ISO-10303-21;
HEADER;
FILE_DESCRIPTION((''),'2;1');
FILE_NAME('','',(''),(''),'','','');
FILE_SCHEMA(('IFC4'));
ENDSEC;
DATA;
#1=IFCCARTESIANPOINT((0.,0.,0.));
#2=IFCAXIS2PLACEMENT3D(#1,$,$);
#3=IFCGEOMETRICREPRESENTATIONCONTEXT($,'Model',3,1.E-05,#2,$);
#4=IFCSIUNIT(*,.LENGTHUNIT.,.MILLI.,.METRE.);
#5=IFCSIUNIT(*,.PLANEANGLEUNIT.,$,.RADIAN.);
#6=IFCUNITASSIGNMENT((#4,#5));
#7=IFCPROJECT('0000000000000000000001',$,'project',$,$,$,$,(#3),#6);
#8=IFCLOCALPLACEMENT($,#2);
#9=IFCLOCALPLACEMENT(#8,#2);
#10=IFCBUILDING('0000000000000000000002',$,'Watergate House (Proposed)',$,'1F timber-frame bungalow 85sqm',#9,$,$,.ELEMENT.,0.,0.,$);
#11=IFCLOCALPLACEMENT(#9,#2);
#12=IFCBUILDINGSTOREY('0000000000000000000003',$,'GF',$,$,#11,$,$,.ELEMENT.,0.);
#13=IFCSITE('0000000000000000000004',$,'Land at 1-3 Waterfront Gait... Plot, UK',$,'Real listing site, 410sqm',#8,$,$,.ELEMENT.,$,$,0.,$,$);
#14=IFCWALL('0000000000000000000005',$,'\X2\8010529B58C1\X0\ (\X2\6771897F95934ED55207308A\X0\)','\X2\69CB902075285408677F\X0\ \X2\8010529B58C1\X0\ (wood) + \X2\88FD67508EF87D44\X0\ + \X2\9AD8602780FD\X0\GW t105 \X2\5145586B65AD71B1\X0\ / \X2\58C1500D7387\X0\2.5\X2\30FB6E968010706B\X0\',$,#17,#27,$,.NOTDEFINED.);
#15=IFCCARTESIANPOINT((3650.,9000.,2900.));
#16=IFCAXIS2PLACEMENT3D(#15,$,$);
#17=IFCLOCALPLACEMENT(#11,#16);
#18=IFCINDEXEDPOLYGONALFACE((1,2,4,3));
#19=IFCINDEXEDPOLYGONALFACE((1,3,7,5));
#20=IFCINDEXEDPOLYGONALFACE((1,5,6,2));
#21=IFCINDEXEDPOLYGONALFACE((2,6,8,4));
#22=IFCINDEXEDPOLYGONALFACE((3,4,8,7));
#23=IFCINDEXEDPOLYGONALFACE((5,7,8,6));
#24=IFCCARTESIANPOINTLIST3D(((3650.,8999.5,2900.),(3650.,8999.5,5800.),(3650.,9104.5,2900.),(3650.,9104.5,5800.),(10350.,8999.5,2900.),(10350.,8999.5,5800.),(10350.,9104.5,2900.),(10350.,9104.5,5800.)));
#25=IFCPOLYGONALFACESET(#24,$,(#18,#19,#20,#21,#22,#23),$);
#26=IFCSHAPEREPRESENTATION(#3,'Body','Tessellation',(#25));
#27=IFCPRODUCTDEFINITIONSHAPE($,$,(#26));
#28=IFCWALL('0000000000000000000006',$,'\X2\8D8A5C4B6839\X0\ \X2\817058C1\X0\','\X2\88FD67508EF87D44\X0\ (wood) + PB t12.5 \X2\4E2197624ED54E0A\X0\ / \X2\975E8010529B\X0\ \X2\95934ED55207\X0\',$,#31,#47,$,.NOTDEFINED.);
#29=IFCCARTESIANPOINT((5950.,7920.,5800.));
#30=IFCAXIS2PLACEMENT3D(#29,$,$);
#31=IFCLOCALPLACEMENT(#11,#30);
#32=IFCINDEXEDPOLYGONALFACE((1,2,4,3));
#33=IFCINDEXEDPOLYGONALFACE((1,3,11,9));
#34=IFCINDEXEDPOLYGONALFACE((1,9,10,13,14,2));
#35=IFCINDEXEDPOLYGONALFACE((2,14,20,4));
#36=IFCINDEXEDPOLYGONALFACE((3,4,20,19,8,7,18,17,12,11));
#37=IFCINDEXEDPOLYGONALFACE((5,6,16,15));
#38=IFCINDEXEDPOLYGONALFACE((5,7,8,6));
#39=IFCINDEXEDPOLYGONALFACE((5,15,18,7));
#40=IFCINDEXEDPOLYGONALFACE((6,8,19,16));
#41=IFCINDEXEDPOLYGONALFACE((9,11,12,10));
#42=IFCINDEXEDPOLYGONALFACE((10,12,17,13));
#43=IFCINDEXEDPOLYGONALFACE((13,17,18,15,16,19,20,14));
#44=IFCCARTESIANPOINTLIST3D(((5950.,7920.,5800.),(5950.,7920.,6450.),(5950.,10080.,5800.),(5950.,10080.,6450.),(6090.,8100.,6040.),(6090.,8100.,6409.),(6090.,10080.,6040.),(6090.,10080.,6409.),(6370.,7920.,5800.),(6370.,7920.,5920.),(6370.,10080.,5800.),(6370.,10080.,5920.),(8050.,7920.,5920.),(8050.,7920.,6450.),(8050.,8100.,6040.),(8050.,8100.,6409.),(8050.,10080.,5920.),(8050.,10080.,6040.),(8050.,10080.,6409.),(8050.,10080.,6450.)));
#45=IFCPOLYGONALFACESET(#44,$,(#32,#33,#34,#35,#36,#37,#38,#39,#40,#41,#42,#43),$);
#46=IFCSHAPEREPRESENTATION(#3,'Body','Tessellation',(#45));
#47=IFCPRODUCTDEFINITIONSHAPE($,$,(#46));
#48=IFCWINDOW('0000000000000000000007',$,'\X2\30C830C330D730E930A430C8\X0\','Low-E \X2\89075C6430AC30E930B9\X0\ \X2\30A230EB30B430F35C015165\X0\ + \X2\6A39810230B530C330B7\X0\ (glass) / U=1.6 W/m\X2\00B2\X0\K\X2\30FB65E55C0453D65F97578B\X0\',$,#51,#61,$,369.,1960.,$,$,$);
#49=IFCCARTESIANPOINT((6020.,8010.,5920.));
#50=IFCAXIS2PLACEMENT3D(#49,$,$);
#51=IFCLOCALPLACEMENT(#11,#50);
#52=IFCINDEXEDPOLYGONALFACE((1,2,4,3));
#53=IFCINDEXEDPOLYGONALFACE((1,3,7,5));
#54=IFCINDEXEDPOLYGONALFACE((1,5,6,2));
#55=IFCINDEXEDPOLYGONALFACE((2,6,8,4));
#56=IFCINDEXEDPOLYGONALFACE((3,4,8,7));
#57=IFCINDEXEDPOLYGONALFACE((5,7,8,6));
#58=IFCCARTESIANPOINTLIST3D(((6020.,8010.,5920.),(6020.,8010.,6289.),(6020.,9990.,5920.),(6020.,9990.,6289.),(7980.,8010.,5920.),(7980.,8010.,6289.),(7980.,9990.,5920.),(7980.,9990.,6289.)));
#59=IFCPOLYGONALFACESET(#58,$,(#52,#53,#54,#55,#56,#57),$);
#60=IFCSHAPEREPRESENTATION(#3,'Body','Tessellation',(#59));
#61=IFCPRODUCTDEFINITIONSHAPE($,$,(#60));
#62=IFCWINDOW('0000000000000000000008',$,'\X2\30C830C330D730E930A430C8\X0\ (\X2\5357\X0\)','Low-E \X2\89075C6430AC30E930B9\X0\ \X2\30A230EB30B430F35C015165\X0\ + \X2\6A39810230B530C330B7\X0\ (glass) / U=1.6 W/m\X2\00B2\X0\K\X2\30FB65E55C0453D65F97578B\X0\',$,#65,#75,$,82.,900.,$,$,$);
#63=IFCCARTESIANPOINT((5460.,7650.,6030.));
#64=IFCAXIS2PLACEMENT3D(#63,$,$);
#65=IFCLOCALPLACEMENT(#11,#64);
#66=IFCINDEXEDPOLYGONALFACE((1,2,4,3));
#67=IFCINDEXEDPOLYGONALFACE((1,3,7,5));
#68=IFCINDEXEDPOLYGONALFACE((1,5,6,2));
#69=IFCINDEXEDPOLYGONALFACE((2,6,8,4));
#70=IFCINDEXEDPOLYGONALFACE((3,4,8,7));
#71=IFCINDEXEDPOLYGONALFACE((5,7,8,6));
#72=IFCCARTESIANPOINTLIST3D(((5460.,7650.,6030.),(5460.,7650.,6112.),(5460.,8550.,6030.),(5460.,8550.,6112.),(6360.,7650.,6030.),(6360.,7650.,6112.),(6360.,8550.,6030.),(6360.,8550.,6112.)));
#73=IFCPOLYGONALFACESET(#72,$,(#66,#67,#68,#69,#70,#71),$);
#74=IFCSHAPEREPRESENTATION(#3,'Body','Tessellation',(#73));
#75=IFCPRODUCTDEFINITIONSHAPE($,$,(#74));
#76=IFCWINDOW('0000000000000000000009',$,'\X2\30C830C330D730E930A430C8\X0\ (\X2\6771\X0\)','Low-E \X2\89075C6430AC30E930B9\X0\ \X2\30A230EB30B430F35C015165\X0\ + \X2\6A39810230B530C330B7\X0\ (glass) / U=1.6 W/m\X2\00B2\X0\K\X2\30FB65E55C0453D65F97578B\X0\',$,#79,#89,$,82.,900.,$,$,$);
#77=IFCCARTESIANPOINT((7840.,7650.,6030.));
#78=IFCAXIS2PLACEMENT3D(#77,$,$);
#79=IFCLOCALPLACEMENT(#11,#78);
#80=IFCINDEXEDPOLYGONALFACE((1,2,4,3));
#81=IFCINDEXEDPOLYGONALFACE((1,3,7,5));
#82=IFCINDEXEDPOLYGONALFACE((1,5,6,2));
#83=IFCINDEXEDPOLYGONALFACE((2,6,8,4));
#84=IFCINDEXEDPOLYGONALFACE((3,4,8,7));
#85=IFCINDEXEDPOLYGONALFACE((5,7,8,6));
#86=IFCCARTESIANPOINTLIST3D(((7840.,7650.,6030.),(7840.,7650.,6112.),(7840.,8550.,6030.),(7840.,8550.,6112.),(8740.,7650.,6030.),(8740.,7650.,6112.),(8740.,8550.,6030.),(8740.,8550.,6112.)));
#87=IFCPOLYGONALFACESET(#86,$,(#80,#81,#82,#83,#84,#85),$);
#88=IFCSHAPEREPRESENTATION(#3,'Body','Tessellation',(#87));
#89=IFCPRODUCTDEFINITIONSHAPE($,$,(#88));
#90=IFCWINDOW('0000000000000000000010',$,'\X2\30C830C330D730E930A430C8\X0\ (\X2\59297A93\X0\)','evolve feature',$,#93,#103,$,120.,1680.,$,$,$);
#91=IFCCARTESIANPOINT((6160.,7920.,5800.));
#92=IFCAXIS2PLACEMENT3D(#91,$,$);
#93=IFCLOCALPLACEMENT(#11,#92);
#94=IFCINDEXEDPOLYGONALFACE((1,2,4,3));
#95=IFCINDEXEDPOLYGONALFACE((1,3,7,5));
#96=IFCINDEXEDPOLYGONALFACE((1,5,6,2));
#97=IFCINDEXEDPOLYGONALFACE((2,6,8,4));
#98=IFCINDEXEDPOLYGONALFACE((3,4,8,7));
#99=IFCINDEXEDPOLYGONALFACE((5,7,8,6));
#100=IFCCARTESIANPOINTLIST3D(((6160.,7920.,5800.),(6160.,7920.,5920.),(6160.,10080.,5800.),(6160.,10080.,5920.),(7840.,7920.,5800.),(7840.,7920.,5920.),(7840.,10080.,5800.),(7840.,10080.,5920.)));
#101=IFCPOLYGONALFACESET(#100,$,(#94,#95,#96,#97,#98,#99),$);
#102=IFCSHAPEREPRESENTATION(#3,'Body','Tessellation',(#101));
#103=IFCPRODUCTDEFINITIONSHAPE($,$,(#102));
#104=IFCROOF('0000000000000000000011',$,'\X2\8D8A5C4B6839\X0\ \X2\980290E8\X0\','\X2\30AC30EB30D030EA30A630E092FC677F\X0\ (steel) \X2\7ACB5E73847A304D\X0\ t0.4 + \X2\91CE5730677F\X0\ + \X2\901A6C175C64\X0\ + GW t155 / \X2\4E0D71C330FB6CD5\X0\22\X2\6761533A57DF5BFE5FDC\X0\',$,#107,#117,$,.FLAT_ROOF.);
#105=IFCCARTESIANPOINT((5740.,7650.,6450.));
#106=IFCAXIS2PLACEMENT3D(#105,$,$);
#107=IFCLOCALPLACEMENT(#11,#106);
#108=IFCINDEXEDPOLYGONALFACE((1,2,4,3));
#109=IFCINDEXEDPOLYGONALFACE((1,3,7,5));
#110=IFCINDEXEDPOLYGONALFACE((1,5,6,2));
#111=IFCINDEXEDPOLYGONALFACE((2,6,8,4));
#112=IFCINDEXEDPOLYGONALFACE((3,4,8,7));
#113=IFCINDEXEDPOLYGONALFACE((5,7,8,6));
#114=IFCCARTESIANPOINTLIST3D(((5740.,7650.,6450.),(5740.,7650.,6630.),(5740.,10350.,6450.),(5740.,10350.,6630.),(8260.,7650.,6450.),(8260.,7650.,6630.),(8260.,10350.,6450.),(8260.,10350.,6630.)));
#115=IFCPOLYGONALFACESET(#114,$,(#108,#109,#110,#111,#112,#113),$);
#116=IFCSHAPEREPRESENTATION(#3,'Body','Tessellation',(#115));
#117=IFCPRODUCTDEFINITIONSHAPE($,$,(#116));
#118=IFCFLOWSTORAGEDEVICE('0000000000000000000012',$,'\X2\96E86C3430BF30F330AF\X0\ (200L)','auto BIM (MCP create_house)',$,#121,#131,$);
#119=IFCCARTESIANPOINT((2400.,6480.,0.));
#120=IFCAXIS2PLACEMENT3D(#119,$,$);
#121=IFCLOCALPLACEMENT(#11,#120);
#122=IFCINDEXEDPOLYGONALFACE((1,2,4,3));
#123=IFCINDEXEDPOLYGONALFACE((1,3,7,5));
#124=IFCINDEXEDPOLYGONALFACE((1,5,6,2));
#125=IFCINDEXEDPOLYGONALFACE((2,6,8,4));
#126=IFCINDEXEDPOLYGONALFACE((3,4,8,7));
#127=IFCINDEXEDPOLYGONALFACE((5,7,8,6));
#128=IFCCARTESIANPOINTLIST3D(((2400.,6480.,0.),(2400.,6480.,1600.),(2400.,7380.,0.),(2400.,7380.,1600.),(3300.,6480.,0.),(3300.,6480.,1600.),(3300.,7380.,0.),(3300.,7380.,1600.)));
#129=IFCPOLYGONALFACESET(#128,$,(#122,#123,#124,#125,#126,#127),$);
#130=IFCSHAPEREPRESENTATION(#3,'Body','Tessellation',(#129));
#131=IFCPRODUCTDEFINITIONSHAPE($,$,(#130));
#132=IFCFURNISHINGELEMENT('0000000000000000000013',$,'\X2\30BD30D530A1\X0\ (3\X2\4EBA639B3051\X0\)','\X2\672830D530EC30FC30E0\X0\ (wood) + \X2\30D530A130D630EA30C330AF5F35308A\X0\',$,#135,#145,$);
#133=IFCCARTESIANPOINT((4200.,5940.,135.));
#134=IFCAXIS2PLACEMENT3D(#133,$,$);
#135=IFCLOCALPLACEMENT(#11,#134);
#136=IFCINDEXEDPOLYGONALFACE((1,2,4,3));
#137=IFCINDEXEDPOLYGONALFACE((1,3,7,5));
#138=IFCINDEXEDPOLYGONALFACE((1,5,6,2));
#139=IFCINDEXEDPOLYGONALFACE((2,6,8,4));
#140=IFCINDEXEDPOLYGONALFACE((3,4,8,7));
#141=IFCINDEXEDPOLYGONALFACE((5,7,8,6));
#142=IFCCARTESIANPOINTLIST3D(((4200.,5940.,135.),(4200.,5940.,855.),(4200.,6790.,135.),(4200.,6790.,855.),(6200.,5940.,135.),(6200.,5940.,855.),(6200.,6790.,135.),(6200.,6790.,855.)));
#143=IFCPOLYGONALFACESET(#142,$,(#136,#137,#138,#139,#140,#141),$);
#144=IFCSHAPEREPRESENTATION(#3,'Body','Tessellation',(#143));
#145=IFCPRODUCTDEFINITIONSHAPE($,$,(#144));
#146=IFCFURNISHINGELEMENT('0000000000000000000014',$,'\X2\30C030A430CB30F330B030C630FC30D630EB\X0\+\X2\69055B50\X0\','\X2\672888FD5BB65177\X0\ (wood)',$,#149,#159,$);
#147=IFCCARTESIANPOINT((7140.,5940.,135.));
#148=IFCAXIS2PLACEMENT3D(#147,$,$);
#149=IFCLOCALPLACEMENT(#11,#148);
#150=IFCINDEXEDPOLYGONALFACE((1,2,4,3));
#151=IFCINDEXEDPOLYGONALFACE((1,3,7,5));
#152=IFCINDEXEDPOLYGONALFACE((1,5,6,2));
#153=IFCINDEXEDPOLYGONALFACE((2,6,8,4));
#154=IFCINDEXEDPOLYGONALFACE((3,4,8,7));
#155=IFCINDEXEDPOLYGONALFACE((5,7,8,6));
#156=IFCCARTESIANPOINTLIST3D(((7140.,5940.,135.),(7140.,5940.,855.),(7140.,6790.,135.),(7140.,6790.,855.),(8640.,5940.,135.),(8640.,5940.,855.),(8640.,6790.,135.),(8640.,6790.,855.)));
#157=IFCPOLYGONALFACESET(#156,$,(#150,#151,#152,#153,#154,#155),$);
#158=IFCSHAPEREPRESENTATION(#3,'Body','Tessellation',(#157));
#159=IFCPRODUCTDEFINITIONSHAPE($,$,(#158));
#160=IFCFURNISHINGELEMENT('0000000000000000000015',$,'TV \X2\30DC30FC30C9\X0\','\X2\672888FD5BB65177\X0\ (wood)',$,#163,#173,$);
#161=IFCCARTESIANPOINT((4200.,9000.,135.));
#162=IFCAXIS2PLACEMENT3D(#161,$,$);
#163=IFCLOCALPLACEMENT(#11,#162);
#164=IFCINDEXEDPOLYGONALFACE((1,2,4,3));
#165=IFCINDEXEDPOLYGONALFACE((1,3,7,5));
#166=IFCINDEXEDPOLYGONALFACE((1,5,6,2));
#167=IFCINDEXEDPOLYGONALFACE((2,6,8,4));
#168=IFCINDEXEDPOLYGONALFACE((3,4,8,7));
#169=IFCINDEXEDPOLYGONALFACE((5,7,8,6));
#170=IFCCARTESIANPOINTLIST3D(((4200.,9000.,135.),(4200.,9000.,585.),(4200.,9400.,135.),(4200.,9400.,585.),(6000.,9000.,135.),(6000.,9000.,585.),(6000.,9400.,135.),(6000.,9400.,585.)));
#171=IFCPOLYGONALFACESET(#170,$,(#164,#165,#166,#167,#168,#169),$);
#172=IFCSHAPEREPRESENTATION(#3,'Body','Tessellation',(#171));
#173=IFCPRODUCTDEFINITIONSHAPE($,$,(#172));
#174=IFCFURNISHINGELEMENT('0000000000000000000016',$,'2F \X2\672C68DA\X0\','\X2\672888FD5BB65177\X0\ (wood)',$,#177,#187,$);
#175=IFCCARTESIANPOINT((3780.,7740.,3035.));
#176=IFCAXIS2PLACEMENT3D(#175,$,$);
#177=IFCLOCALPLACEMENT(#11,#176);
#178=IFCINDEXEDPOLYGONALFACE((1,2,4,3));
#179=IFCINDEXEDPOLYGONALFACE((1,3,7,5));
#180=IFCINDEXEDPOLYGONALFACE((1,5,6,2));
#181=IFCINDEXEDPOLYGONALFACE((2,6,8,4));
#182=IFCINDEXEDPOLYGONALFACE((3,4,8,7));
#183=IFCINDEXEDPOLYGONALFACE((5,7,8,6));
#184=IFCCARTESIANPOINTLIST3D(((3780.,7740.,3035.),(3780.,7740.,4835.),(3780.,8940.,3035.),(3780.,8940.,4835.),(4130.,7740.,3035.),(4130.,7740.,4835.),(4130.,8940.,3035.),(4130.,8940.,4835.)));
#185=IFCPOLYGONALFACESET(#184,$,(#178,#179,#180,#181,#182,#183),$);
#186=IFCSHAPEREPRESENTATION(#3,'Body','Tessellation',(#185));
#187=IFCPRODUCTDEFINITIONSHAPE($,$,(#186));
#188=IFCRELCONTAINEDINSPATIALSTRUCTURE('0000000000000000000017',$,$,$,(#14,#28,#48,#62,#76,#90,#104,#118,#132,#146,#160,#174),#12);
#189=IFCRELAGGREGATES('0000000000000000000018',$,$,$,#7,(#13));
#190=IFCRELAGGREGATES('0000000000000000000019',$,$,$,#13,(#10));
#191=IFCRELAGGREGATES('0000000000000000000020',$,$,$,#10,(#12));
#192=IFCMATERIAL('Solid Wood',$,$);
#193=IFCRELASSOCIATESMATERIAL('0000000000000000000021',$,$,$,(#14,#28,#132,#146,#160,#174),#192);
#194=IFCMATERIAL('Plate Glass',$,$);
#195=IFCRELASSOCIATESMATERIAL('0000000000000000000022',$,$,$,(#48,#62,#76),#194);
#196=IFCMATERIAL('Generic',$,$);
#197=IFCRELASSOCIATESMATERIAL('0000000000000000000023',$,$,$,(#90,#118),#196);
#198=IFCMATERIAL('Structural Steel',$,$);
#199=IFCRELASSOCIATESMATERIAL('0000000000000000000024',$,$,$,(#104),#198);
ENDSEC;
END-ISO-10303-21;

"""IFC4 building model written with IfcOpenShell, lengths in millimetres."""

from ifc_helpers import new_model, si_unit, frame, frame_2d, origin, place, context, project, spatial, rectangle, extrude, material, element, fill, save


model = new_model("IFC4")

# Units and contexts
model_context = context("Model", 3, precision=1e-05, world=origin())
ifc_project = project(units=[si_unit("LENGTHUNIT", "METRE", prefix="MILLI"), si_unit("PLANEANGLEUNIT", "RADIAN")], contexts=[model_context])

# Site, building, storey
site_placement = place(None, origin())
site = spatial("IfcSite", under=ifc_project, at=site_placement, Name="Land at 1-3 Waterfront Gait... Plot, UK", ObjectType="Real listing site, 410sqm", CompositionType="ELEMENT", RefElevation=0.0)
building_placement = place(site_placement, origin())
building = spatial("IfcBuilding", under=site, at=building_placement, Name="Watergate House (Proposed)", ObjectType="1F timber-frame bungalow 85sqm", CompositionType="ELEMENT", ElevationOfRefHeight=0.0, ElevationOfTerrain=0.0)
storey_placement = place(building_placement, origin())
storey = spatial("IfcBuildingStorey", under=building, at=storey_placement, Name="GF", CompositionType="ELEMENT", Elevation=0.0)

# Wall
ifc_material_1 = material(Name="Solid Wood")
wall_1_placement = place(storey_placement, frame((3650.0, 9000.0, 2900.0)))
element("IfcWall", 1, at=wall_1_placement, inside=storey, material=ifc_material_1, Name="耐力壁 (東西間仕切り)", Description="構造用合板 耐力壁 (wood) + 製材軸組 + 高性能GW t105 充填断熱 / 壁倍率2.5・準耐火", PredefinedType="NOTDEFINED", context=model_context, shape_type="SweptSolid", body=[
    extrude(rectangle(XDim=6700.0, YDim=105.0, at=frame_2d((3350.0, 52.0))), frame((3650.0, 9000.0, 2900.0)), (0.0, 0.0, 1.0), 2900.0),
])

# Wall, openings, windows
wall_2_placement = place(storey_placement, frame((5950.0, 7920.0, 5800.0)))
wall_2 = element("IfcWall", 2, at=wall_2_placement, inside=storey, material=ifc_material_1, Name="越屋根 腰壁", Description="製材軸組 (wood) + PB t12.5 両面仕上 / 非耐力 間仕切", PredefinedType="NOTDEFINED", context=model_context, shape_type="SweptSolid", body=[
    extrude(rectangle(XDim=2100.0, YDim=2160.0, at=frame_2d((1050.0, 1080.0))), frame((5950.0, 7920.0, 5800.0)), (0.0, 0.0, 1.0), 650.0),
])
opening_1_placement = place(storey_placement, frame((6020.0, 8010.0, 5920.0)))
opening_1 = element("IfcOpeningElement", 3, at=opening_1_placement, cuts=wall_2, PredefinedType="NOTDEFINED", context=model_context, shape_type="SweptSolid", body=[
    extrude(rectangle(XDim=1960.0, YDim=1980.0, at=frame_2d((980.0, 990.0))), frame((6020.0, 8010.0, 5920.0)), (0.0, 0.0, 1.0), 369.0),
])
opening_2_placement = place(storey_placement, frame((5460.0, 7650.0, 6030.0)))
opening_2 = element("IfcOpeningElement", 4, at=opening_2_placement, cuts=wall_2, PredefinedType="NOTDEFINED", context=model_context, shape_type="SweptSolid", body=[
    extrude(rectangle(XDim=900.0, YDim=900.0, at=frame_2d((450.0, 450.0))), frame((5460.0, 7650.0, 6030.0)), (0.0, 0.0, 1.0), 82.0),
])
opening_3_placement = place(storey_placement, frame((7840.0, 7650.0, 6030.0)))
opening_3 = element("IfcOpeningElement", 5, at=opening_3_placement, cuts=wall_2, PredefinedType="NOTDEFINED", context=model_context, shape_type="SweptSolid", body=[
    extrude(rectangle(XDim=900.0, YDim=900.0, at=frame_2d((450.0, 450.0))), frame((7840.0, 7650.0, 6030.0)), (0.0, 0.0, 1.0), 82.0),
])
opening_4_placement = place(storey_placement, frame((6160.0, 7920.0, 5800.0)))
opening_4 = element("IfcOpeningElement", 6, at=opening_4_placement, cuts=wall_2, PredefinedType="NOTDEFINED", context=model_context, shape_type="SweptSolid", body=[
    extrude(rectangle(XDim=1680.0, YDim=2160.0, at=frame_2d((840.0, 1080.0))), frame((6160.0, 7920.0, 5800.0)), (0.0, 0.0, 1.0), 120.0),
])
ifc_material_2 = material(Name="Plate Glass")
window_1_placement = place(storey_placement, frame((6020.0, 8010.0, 5920.0)))
window_1 = element("IfcWindow", 7, at=window_1_placement, inside=storey, material=ifc_material_2, Name="トップライト", Description="Low-E 複層ガラス アルゴン封入 + 樹脂サッシ (glass) / U=1.6 W/m²K・日射取得型", OverallHeight=369.0, OverallWidth=1960.0, context=model_context, shape_type="SweptSolid", body=[
    extrude(rectangle(XDim=1960.0, YDim=1980.0, at=frame_2d((980.0, 990.0))), frame((6020.0, 8010.0, 5920.0)), (0.0, 0.0, 1.0), 369.0),
])
fill(opening_1, window_1)
window_2_placement = place(storey_placement, frame((5460.0, 7650.0, 6030.0)))
window_2 = element("IfcWindow", 8, at=window_2_placement, inside=storey, material=ifc_material_2, Name="トップライト (南)", Description="Low-E 複層ガラス アルゴン封入 + 樹脂サッシ (glass) / U=1.6 W/m²K・日射取得型", OverallHeight=82.0, OverallWidth=900.0, context=model_context, shape_type="SweptSolid", body=[
    extrude(rectangle(XDim=900.0, YDim=900.0, at=frame_2d((450.0, 450.0))), frame((5460.0, 7650.0, 6030.0)), (0.0, 0.0, 1.0), 82.0),
])
fill(opening_2, window_2)
window_3_placement = place(storey_placement, frame((7840.0, 7650.0, 6030.0)))
window_3 = element("IfcWindow", 9, at=window_3_placement, inside=storey, material=ifc_material_2, Name="トップライト (東)", Description="Low-E 複層ガラス アルゴン封入 + 樹脂サッシ (glass) / U=1.6 W/m²K・日射取得型", OverallHeight=82.0, OverallWidth=900.0, context=model_context, shape_type="SweptSolid", body=[
    extrude(rectangle(XDim=900.0, YDim=900.0, at=frame_2d((450.0, 450.0))), frame((7840.0, 7650.0, 6030.0)), (0.0, 0.0, 1.0), 82.0),
])
fill(opening_3, window_3)
ifc_material_3 = material(Name="Generic")
window_4_placement = place(storey_placement, frame((6160.0, 7920.0, 5800.0)))
window_4 = element("IfcWindow", 10, at=window_4_placement, inside=storey, material=ifc_material_3, Name="トップライト (天窓)", Description="evolve feature", OverallHeight=120.0, OverallWidth=1680.0, context=model_context, shape_type="SweptSolid", body=[
    extrude(rectangle(XDim=1680.0, YDim=2160.0, at=frame_2d((840.0, 1080.0))), frame((6160.0, 7920.0, 5800.0)), (0.0, 0.0, 1.0), 120.0),
])
fill(opening_4, window_4)

# Roof
ifc_material_4 = material(Name="Structural Steel")
roof_placement = place(storey_placement, frame((5740.0, 7650.0, 6450.0)))
element("IfcRoof", 11, at=roof_placement, inside=storey, material=ifc_material_4, Name="越屋根 頂部", Description="ガルバリウム鋼板 (steel) 立平葺き t0.4 + 野地板 + 通気層 + GW t155 / 不燃・法22条区域対応", PredefinedType="FLAT_ROOF", context=model_context, shape_type="SweptSolid", body=[
    extrude(rectangle(XDim=2520.0, YDim=2700.0, at=frame_2d((1260.0, 1350.0))), frame((5740.0, 7650.0, 6450.0)), (0.0, 0.0, 1.0), 180.0),
])

# Flow storage device
flow_storage_device_placement = place(storey_placement, frame((2400.0, 6480.0, 0.0)))
element("IfcFlowStorageDevice", 12, at=flow_storage_device_placement, inside=storey, material=ifc_material_3, Name="雨水タンク (200L)", Description="auto BIM (MCP create_house)", context=model_context, shape_type="SweptSolid", body=[
    extrude(rectangle(XDim=900.0, YDim=900.0, at=frame_2d((450.0, 450.0))), frame((2400.0, 6480.0, 0.0)), (0.0, 0.0, 1.0), 1600.0),
])

# Furnishing elements
furnishing_1_placement = place(storey_placement, frame((4200.0, 5940.0, 135.0)))
element("IfcFurnishingElement", 13, at=furnishing_1_placement, inside=storey, material=ifc_material_1, Name="ソファ (3人掛け)", Description="木フレーム (wood) + ファブリック張り", context=model_context, shape_type="SweptSolid", body=[
    extrude(rectangle(XDim=2000.0, YDim=850.0, at=frame_2d((1000.0, 425.0))), frame((4200.0, 5940.0, 135.0)), (0.0, 0.0, 1.0), 720.0),
])
furnishing_2_placement = place(storey_placement, frame((7140.0, 5940.0, 135.0)))
element("IfcFurnishingElement", 14, at=furnishing_2_placement, inside=storey, material=ifc_material_1, Name="ダイニングテーブル+椅子", Description="木製家具 (wood)", context=model_context, shape_type="SweptSolid", body=[
    extrude(rectangle(XDim=1500.0, YDim=850.0, at=frame_2d((750.0, 425.0))), frame((7140.0, 5940.0, 135.0)), (0.0, 0.0, 1.0), 720.0),
])
furnishing_3_placement = place(storey_placement, frame((4200.0, 9000.0, 135.0)))
element("IfcFurnishingElement", 15, at=furnishing_3_placement, inside=storey, material=ifc_material_1, Name="TV ボード", Description="木製家具 (wood)", context=model_context, shape_type="SweptSolid", body=[
    extrude(rectangle(XDim=1800.0, YDim=400.0, at=frame_2d((900.0, 200.0))), frame((4200.0, 9000.0, 135.0)), (0.0, 0.0, 1.0), 450.0),
])
furnishing_4_placement = place(storey_placement, frame((3780.0, 7740.0, 3035.0)))
element("IfcFurnishingElement", 16, at=furnishing_4_placement, inside=storey, material=ifc_material_1, Name="2F 本棚", Description="木製家具 (wood)", context=model_context, shape_type="SweptSolid", body=[
    extrude(rectangle(XDim=350.0, YDim=1200.0, at=frame_2d((175.0, 600.0))), frame((3780.0, 7740.0, 3035.0)), (0.0, 0.0, 1.0), 1800.0),
])

save(model, "model.ifc")
